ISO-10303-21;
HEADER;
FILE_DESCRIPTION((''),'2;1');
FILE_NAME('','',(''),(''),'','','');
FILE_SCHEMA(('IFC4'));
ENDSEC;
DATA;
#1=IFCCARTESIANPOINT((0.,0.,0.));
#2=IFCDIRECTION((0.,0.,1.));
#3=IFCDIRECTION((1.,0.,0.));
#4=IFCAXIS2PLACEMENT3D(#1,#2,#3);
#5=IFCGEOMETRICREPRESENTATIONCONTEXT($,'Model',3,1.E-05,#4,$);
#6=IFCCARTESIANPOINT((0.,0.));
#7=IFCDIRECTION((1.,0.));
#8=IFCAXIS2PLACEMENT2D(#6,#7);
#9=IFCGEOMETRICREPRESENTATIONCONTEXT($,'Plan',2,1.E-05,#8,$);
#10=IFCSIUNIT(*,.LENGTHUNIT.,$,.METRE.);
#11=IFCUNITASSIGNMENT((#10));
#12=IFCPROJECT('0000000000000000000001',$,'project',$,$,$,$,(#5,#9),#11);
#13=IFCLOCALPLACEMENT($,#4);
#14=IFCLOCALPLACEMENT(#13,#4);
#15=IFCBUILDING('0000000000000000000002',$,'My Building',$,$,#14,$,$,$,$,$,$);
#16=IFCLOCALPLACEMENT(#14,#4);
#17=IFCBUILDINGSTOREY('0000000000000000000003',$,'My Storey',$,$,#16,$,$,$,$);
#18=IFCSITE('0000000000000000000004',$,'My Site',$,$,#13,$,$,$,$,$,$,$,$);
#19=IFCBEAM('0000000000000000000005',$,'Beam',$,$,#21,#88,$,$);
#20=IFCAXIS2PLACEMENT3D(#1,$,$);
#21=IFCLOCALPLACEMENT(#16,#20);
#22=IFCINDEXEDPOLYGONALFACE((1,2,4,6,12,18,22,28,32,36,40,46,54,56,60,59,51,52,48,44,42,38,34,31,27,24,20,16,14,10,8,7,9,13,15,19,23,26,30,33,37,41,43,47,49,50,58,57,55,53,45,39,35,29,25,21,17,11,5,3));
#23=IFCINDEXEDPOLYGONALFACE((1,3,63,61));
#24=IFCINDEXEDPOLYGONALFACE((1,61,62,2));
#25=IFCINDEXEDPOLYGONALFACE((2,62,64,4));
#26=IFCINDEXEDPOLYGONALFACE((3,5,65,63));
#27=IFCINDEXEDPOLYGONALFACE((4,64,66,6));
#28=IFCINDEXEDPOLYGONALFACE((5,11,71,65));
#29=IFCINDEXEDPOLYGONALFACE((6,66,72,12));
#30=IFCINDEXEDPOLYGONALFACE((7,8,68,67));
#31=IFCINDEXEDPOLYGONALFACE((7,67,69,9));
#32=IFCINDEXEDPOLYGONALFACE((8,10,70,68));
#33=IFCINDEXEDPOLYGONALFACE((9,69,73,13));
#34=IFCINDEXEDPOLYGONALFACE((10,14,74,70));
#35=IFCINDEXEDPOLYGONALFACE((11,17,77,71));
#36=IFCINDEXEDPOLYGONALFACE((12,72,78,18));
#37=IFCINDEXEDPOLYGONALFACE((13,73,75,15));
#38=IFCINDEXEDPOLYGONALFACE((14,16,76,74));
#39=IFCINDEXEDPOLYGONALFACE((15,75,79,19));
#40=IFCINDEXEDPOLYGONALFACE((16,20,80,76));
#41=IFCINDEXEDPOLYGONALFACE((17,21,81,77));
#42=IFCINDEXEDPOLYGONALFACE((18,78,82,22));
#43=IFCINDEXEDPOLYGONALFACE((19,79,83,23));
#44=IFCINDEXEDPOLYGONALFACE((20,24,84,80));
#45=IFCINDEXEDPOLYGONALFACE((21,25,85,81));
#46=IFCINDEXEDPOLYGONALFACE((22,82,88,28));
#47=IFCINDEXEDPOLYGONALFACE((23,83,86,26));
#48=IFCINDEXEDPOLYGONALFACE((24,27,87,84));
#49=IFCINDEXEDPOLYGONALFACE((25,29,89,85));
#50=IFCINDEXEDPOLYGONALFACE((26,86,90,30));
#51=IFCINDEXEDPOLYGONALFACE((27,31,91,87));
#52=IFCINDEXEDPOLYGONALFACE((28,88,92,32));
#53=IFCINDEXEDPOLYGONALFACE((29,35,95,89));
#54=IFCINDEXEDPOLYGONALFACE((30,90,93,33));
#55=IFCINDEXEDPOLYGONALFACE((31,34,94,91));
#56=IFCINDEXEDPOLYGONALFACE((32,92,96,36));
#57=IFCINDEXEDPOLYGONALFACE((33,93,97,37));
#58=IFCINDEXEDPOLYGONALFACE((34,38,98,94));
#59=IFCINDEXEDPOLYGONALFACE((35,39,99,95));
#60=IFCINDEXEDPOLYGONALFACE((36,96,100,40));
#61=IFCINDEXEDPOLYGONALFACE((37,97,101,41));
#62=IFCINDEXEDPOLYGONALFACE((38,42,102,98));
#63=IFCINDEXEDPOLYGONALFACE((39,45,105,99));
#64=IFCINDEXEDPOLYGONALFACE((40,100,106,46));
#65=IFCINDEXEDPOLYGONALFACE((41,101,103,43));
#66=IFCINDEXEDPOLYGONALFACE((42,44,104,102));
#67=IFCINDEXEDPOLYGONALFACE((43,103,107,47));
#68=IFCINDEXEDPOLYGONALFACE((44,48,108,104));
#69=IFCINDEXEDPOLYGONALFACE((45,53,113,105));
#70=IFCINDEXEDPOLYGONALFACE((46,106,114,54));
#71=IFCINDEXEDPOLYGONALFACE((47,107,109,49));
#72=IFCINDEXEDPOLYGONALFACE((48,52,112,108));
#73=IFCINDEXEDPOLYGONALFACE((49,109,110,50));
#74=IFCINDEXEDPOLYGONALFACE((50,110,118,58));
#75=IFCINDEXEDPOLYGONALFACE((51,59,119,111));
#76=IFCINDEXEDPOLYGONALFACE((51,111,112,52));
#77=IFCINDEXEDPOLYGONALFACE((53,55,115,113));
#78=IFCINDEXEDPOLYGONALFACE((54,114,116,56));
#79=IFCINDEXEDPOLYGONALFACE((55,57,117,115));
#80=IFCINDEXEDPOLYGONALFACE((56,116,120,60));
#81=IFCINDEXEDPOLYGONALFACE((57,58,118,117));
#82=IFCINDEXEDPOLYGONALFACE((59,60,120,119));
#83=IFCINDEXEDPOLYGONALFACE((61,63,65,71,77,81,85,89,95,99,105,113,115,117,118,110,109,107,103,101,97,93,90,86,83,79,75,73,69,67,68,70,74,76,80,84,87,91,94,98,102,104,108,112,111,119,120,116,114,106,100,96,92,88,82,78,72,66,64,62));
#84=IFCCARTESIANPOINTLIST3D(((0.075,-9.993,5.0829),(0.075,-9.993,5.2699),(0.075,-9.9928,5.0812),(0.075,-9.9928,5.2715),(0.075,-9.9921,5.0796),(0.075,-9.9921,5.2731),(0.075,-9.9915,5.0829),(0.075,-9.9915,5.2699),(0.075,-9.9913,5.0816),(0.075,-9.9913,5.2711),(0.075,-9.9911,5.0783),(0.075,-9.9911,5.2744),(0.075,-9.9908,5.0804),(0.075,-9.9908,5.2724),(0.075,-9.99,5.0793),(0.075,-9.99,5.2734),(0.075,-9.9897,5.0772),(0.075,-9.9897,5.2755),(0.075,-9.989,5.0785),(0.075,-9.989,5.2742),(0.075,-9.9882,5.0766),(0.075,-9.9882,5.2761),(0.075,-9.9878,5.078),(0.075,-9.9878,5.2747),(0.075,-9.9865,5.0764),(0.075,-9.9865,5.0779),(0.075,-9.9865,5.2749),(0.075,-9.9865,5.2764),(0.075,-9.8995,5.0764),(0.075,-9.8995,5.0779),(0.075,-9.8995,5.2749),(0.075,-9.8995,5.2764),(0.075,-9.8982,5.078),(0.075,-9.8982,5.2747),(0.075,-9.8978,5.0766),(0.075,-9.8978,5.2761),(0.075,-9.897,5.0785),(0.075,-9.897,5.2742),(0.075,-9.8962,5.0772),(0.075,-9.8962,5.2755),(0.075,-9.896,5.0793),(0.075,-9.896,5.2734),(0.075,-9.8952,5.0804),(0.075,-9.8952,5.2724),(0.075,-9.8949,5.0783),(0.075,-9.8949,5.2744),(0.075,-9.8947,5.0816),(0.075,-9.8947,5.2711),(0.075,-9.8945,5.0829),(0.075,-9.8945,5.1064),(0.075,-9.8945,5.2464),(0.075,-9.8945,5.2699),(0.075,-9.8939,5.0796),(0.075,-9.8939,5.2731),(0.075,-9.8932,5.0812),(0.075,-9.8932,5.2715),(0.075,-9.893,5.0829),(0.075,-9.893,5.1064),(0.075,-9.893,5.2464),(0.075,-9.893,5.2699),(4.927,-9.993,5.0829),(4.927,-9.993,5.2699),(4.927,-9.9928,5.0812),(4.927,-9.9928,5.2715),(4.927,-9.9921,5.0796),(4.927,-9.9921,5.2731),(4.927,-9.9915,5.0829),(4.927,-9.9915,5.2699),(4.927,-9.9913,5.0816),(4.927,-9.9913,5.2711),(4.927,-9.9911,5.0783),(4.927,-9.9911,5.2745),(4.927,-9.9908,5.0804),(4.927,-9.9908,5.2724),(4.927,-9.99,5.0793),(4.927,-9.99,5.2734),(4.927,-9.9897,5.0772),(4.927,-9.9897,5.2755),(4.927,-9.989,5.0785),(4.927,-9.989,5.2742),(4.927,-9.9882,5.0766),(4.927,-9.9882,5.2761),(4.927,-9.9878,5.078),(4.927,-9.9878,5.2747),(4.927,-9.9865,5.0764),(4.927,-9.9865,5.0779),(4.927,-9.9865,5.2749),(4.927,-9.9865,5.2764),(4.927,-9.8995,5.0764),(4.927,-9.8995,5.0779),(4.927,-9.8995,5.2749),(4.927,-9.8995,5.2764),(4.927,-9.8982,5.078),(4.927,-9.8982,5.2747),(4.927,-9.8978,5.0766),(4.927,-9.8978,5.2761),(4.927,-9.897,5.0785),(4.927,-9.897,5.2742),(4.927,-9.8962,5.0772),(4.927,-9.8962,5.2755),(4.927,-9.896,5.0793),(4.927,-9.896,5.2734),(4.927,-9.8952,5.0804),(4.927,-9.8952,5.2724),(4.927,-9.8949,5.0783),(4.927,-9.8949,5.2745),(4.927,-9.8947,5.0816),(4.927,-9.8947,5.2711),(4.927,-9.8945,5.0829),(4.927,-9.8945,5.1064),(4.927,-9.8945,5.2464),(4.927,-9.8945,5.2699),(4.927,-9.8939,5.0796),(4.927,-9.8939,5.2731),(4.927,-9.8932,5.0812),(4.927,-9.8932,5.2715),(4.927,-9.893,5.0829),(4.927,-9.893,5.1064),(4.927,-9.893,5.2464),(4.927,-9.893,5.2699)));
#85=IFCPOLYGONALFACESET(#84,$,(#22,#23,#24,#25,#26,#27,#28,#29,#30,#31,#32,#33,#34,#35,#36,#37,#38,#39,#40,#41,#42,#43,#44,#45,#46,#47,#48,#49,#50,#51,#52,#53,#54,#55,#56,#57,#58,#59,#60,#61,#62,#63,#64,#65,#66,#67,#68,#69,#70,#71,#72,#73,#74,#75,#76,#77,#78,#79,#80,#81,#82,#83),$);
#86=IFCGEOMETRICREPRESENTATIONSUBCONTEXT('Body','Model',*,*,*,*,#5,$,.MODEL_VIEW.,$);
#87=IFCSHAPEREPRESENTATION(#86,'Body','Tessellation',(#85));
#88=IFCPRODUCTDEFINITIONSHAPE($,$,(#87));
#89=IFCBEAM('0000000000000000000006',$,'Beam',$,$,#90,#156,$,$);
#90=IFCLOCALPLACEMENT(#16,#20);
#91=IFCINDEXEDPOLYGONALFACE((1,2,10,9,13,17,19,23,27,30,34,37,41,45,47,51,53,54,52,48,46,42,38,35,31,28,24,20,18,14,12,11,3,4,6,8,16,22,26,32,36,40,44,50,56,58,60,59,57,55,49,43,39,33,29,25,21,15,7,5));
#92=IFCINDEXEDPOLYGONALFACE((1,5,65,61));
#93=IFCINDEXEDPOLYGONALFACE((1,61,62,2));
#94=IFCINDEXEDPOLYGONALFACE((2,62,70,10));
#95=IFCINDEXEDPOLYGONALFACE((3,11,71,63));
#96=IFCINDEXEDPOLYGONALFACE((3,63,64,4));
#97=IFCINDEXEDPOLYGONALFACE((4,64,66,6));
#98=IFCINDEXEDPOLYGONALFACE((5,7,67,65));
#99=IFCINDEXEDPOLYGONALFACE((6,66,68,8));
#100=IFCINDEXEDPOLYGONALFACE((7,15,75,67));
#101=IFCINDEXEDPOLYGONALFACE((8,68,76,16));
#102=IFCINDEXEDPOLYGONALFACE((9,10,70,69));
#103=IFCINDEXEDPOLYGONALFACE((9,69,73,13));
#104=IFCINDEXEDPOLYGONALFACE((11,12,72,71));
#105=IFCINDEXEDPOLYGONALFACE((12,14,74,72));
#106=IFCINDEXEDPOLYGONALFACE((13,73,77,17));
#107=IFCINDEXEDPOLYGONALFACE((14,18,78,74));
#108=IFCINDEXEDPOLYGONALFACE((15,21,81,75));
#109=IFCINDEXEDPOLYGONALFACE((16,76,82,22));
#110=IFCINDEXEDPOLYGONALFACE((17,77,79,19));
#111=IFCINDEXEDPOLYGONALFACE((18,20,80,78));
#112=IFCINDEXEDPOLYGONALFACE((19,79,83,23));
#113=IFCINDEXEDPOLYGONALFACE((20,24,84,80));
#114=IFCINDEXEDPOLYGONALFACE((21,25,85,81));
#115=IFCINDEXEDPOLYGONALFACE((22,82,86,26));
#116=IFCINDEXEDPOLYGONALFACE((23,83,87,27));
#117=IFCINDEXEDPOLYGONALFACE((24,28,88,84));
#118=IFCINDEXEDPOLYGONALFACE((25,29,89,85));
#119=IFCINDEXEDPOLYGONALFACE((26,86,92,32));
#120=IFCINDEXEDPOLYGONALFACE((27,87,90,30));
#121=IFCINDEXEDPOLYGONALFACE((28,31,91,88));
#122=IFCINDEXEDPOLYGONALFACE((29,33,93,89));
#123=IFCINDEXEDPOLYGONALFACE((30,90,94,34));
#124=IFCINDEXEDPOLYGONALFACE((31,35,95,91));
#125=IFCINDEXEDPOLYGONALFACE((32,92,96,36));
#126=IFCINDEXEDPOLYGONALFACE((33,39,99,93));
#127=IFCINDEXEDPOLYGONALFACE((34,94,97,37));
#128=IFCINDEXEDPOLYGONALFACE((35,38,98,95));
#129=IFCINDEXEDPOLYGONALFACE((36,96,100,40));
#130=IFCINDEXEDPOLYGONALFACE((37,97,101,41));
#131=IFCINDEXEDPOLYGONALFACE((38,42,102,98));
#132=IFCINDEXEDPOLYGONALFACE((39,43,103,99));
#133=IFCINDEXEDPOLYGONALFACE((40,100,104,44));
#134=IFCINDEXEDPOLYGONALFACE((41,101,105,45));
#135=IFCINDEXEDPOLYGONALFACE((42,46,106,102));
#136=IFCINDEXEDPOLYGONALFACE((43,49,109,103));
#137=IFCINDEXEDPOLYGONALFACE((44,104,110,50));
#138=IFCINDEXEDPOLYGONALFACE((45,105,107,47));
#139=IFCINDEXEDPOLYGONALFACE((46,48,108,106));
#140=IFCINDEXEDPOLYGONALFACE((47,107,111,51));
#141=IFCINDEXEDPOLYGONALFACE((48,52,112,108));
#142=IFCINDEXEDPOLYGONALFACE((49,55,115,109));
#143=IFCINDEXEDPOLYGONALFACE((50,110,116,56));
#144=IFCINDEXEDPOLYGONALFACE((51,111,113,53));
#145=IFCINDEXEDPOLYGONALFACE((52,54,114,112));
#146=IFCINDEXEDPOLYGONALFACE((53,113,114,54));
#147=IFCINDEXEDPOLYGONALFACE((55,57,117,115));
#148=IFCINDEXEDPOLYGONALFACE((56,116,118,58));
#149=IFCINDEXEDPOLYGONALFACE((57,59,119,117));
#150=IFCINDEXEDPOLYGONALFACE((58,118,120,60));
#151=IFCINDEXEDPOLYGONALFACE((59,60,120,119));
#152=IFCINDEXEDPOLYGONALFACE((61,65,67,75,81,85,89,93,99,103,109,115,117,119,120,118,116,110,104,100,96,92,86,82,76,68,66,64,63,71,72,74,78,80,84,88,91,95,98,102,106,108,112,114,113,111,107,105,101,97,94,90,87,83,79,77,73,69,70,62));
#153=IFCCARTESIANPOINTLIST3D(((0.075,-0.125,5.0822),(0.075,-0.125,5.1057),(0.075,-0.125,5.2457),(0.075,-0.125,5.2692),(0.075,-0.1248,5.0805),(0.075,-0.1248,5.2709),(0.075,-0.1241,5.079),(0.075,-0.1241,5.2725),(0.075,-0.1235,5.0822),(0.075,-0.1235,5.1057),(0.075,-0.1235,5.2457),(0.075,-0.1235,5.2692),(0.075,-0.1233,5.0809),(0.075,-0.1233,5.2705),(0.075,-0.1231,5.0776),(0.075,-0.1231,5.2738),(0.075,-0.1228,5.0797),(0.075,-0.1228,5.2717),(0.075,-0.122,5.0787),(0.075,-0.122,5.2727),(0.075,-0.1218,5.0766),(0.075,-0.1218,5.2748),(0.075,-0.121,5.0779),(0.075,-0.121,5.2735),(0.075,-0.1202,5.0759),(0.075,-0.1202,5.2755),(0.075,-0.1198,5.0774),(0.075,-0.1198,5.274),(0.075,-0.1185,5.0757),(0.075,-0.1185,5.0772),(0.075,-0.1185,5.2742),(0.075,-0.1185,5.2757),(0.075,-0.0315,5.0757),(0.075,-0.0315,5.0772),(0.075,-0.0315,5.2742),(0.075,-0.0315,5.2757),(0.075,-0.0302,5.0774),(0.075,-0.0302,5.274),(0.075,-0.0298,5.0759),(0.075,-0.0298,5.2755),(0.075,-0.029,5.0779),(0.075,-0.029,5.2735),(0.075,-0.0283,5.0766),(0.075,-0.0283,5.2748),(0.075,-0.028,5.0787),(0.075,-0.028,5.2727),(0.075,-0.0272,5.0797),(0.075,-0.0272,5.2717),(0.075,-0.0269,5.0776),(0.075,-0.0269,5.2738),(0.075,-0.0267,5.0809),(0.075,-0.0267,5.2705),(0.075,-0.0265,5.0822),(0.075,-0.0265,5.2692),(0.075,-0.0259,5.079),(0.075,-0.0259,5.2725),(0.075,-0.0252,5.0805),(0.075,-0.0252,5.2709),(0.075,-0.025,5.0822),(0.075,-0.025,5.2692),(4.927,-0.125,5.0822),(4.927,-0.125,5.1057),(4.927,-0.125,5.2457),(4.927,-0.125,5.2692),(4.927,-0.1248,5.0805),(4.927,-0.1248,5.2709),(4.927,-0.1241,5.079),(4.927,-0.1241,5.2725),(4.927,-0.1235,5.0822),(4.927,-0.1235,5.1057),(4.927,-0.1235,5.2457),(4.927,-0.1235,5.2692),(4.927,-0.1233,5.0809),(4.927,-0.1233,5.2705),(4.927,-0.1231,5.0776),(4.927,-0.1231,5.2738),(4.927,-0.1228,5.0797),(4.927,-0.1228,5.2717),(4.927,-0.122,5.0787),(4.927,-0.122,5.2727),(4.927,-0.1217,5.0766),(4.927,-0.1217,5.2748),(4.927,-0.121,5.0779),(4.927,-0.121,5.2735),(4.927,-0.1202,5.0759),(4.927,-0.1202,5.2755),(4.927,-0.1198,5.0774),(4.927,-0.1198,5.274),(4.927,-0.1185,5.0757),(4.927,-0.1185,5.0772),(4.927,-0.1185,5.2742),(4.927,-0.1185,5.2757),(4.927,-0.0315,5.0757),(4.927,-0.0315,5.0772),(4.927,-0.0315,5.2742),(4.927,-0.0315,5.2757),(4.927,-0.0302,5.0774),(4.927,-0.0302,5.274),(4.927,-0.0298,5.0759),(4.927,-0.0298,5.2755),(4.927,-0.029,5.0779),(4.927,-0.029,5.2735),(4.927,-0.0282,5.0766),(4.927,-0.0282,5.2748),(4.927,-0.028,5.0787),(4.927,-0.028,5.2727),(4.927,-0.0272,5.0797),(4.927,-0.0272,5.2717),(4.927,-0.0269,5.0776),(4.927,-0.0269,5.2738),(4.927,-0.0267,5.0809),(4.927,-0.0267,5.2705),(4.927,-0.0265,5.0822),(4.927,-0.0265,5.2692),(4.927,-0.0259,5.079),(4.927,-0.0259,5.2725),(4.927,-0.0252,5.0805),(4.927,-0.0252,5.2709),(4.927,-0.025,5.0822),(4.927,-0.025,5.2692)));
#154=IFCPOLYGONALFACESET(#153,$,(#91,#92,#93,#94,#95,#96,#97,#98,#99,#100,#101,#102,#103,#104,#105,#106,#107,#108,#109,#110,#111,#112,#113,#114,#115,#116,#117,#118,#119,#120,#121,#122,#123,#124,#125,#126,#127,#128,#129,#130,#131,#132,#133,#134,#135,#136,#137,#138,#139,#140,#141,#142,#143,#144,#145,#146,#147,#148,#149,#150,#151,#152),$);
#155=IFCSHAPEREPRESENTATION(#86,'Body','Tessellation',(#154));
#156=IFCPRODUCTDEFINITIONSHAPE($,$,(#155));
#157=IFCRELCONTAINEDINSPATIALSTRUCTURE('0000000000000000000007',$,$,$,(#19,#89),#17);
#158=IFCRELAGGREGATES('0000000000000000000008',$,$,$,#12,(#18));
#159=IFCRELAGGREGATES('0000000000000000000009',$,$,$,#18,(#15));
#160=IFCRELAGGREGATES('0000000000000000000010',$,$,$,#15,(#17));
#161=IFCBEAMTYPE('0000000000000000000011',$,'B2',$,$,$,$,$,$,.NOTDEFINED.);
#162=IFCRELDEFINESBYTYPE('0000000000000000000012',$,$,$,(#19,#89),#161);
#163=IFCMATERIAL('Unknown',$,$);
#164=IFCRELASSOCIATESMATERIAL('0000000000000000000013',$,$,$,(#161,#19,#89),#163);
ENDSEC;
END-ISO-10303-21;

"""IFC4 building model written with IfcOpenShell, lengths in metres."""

from ifc_helpers import new_model, si_unit, frame, origin_with_axes, origin_2d_with_axis, place, context, subcontext, project, spatial, c_section, extrude, material, material_profile, profile_set, profile_usage, type_object, element, save


model = new_model("IFC4")

# Units and contexts
model_context = context("Model", 3, precision=1e-05, world=origin_with_axes())
plan_context = context("Plan", 2, precision=1e-05, world=origin_2d_with_axis())
body_context = subcontext(model_context, "Body", "Model", "MODEL_VIEW")
ifc_project = project(units=[si_unit("LENGTHUNIT", "METRE")], contexts=[model_context, plan_context])

# Site, building, storey
site_placement = place(None, origin_with_axes())
site = spatial("IfcSite", under=ifc_project, at=site_placement, Name="My Site")
building_placement = place(site_placement, origin_with_axes())
building = spatial("IfcBuilding", under=site, at=building_placement, Name="My Building")
storey_placement = place(building_placement, origin_with_axes())
storey = spatial("IfcBuildingStorey", under=building, at=storey_placement, Name="My Storey")

# Shared definitions
ifc_material = material(Name="Unknown")

# Beams
ifc_material_profile_1 = material_profile(ifc_material, c_section(Depth=0.2, Width=0.1, WallThickness=0.0015, Girth=0.03, InternalFilletRadius=0.005))
ifc_profile_set_1 = profile_set([ifc_material_profile_1])
beam_type = type_object("IfcBeamType", Name="B2", PredefinedType="NOTDEFINED", material=ifc_profile_set_1)
ifc_profile_usage_1 = profile_usage(ifc_profile_set_1, cardinal=5)
beam_1_placement = place(storey_placement, frame((4.927, -9.943, 5.1764), z_axis=(-1.0, 0.0, 0.0), x_axis=(0.0, 1.0, 0.0)))
element("IfcBeam", 1, at=beam_1_placement, inside=storey, type_object=beam_type, material=ifc_profile_usage_1, Name="Beam", context=body_context, shape_type="SweptSolid", body=[
    extrude(c_section(Depth=0.2, Width=0.1, WallThickness=0.0015, Girth=0.03, InternalFilletRadius=0.005), origin_with_axes(), (0.0, 0.0, 1.0), 4.852),
])
ifc_profile_usage_2 = profile_usage(ifc_profile_set_1, cardinal=5)
beam_2_placement = place(storey_placement, frame((4.927, -0.075, 5.1757), z_axis=(-1.0, 0.0, 0.0), x_axis=(0.0, -1.0, 0.0)))
element("IfcBeam", 2, at=beam_2_placement, inside=storey, type_object=beam_type, material=ifc_profile_usage_2, Name="Beam", context=body_context, shape_type="SweptSolid", body=[
    extrude(c_section(Depth=0.2, Width=0.1, WallThickness=0.0015, Girth=0.03, InternalFilletRadius=0.005), origin_with_axes(), (0.0, 0.0, 1.0), 4.852),
])

save(model, "model.ifc")
